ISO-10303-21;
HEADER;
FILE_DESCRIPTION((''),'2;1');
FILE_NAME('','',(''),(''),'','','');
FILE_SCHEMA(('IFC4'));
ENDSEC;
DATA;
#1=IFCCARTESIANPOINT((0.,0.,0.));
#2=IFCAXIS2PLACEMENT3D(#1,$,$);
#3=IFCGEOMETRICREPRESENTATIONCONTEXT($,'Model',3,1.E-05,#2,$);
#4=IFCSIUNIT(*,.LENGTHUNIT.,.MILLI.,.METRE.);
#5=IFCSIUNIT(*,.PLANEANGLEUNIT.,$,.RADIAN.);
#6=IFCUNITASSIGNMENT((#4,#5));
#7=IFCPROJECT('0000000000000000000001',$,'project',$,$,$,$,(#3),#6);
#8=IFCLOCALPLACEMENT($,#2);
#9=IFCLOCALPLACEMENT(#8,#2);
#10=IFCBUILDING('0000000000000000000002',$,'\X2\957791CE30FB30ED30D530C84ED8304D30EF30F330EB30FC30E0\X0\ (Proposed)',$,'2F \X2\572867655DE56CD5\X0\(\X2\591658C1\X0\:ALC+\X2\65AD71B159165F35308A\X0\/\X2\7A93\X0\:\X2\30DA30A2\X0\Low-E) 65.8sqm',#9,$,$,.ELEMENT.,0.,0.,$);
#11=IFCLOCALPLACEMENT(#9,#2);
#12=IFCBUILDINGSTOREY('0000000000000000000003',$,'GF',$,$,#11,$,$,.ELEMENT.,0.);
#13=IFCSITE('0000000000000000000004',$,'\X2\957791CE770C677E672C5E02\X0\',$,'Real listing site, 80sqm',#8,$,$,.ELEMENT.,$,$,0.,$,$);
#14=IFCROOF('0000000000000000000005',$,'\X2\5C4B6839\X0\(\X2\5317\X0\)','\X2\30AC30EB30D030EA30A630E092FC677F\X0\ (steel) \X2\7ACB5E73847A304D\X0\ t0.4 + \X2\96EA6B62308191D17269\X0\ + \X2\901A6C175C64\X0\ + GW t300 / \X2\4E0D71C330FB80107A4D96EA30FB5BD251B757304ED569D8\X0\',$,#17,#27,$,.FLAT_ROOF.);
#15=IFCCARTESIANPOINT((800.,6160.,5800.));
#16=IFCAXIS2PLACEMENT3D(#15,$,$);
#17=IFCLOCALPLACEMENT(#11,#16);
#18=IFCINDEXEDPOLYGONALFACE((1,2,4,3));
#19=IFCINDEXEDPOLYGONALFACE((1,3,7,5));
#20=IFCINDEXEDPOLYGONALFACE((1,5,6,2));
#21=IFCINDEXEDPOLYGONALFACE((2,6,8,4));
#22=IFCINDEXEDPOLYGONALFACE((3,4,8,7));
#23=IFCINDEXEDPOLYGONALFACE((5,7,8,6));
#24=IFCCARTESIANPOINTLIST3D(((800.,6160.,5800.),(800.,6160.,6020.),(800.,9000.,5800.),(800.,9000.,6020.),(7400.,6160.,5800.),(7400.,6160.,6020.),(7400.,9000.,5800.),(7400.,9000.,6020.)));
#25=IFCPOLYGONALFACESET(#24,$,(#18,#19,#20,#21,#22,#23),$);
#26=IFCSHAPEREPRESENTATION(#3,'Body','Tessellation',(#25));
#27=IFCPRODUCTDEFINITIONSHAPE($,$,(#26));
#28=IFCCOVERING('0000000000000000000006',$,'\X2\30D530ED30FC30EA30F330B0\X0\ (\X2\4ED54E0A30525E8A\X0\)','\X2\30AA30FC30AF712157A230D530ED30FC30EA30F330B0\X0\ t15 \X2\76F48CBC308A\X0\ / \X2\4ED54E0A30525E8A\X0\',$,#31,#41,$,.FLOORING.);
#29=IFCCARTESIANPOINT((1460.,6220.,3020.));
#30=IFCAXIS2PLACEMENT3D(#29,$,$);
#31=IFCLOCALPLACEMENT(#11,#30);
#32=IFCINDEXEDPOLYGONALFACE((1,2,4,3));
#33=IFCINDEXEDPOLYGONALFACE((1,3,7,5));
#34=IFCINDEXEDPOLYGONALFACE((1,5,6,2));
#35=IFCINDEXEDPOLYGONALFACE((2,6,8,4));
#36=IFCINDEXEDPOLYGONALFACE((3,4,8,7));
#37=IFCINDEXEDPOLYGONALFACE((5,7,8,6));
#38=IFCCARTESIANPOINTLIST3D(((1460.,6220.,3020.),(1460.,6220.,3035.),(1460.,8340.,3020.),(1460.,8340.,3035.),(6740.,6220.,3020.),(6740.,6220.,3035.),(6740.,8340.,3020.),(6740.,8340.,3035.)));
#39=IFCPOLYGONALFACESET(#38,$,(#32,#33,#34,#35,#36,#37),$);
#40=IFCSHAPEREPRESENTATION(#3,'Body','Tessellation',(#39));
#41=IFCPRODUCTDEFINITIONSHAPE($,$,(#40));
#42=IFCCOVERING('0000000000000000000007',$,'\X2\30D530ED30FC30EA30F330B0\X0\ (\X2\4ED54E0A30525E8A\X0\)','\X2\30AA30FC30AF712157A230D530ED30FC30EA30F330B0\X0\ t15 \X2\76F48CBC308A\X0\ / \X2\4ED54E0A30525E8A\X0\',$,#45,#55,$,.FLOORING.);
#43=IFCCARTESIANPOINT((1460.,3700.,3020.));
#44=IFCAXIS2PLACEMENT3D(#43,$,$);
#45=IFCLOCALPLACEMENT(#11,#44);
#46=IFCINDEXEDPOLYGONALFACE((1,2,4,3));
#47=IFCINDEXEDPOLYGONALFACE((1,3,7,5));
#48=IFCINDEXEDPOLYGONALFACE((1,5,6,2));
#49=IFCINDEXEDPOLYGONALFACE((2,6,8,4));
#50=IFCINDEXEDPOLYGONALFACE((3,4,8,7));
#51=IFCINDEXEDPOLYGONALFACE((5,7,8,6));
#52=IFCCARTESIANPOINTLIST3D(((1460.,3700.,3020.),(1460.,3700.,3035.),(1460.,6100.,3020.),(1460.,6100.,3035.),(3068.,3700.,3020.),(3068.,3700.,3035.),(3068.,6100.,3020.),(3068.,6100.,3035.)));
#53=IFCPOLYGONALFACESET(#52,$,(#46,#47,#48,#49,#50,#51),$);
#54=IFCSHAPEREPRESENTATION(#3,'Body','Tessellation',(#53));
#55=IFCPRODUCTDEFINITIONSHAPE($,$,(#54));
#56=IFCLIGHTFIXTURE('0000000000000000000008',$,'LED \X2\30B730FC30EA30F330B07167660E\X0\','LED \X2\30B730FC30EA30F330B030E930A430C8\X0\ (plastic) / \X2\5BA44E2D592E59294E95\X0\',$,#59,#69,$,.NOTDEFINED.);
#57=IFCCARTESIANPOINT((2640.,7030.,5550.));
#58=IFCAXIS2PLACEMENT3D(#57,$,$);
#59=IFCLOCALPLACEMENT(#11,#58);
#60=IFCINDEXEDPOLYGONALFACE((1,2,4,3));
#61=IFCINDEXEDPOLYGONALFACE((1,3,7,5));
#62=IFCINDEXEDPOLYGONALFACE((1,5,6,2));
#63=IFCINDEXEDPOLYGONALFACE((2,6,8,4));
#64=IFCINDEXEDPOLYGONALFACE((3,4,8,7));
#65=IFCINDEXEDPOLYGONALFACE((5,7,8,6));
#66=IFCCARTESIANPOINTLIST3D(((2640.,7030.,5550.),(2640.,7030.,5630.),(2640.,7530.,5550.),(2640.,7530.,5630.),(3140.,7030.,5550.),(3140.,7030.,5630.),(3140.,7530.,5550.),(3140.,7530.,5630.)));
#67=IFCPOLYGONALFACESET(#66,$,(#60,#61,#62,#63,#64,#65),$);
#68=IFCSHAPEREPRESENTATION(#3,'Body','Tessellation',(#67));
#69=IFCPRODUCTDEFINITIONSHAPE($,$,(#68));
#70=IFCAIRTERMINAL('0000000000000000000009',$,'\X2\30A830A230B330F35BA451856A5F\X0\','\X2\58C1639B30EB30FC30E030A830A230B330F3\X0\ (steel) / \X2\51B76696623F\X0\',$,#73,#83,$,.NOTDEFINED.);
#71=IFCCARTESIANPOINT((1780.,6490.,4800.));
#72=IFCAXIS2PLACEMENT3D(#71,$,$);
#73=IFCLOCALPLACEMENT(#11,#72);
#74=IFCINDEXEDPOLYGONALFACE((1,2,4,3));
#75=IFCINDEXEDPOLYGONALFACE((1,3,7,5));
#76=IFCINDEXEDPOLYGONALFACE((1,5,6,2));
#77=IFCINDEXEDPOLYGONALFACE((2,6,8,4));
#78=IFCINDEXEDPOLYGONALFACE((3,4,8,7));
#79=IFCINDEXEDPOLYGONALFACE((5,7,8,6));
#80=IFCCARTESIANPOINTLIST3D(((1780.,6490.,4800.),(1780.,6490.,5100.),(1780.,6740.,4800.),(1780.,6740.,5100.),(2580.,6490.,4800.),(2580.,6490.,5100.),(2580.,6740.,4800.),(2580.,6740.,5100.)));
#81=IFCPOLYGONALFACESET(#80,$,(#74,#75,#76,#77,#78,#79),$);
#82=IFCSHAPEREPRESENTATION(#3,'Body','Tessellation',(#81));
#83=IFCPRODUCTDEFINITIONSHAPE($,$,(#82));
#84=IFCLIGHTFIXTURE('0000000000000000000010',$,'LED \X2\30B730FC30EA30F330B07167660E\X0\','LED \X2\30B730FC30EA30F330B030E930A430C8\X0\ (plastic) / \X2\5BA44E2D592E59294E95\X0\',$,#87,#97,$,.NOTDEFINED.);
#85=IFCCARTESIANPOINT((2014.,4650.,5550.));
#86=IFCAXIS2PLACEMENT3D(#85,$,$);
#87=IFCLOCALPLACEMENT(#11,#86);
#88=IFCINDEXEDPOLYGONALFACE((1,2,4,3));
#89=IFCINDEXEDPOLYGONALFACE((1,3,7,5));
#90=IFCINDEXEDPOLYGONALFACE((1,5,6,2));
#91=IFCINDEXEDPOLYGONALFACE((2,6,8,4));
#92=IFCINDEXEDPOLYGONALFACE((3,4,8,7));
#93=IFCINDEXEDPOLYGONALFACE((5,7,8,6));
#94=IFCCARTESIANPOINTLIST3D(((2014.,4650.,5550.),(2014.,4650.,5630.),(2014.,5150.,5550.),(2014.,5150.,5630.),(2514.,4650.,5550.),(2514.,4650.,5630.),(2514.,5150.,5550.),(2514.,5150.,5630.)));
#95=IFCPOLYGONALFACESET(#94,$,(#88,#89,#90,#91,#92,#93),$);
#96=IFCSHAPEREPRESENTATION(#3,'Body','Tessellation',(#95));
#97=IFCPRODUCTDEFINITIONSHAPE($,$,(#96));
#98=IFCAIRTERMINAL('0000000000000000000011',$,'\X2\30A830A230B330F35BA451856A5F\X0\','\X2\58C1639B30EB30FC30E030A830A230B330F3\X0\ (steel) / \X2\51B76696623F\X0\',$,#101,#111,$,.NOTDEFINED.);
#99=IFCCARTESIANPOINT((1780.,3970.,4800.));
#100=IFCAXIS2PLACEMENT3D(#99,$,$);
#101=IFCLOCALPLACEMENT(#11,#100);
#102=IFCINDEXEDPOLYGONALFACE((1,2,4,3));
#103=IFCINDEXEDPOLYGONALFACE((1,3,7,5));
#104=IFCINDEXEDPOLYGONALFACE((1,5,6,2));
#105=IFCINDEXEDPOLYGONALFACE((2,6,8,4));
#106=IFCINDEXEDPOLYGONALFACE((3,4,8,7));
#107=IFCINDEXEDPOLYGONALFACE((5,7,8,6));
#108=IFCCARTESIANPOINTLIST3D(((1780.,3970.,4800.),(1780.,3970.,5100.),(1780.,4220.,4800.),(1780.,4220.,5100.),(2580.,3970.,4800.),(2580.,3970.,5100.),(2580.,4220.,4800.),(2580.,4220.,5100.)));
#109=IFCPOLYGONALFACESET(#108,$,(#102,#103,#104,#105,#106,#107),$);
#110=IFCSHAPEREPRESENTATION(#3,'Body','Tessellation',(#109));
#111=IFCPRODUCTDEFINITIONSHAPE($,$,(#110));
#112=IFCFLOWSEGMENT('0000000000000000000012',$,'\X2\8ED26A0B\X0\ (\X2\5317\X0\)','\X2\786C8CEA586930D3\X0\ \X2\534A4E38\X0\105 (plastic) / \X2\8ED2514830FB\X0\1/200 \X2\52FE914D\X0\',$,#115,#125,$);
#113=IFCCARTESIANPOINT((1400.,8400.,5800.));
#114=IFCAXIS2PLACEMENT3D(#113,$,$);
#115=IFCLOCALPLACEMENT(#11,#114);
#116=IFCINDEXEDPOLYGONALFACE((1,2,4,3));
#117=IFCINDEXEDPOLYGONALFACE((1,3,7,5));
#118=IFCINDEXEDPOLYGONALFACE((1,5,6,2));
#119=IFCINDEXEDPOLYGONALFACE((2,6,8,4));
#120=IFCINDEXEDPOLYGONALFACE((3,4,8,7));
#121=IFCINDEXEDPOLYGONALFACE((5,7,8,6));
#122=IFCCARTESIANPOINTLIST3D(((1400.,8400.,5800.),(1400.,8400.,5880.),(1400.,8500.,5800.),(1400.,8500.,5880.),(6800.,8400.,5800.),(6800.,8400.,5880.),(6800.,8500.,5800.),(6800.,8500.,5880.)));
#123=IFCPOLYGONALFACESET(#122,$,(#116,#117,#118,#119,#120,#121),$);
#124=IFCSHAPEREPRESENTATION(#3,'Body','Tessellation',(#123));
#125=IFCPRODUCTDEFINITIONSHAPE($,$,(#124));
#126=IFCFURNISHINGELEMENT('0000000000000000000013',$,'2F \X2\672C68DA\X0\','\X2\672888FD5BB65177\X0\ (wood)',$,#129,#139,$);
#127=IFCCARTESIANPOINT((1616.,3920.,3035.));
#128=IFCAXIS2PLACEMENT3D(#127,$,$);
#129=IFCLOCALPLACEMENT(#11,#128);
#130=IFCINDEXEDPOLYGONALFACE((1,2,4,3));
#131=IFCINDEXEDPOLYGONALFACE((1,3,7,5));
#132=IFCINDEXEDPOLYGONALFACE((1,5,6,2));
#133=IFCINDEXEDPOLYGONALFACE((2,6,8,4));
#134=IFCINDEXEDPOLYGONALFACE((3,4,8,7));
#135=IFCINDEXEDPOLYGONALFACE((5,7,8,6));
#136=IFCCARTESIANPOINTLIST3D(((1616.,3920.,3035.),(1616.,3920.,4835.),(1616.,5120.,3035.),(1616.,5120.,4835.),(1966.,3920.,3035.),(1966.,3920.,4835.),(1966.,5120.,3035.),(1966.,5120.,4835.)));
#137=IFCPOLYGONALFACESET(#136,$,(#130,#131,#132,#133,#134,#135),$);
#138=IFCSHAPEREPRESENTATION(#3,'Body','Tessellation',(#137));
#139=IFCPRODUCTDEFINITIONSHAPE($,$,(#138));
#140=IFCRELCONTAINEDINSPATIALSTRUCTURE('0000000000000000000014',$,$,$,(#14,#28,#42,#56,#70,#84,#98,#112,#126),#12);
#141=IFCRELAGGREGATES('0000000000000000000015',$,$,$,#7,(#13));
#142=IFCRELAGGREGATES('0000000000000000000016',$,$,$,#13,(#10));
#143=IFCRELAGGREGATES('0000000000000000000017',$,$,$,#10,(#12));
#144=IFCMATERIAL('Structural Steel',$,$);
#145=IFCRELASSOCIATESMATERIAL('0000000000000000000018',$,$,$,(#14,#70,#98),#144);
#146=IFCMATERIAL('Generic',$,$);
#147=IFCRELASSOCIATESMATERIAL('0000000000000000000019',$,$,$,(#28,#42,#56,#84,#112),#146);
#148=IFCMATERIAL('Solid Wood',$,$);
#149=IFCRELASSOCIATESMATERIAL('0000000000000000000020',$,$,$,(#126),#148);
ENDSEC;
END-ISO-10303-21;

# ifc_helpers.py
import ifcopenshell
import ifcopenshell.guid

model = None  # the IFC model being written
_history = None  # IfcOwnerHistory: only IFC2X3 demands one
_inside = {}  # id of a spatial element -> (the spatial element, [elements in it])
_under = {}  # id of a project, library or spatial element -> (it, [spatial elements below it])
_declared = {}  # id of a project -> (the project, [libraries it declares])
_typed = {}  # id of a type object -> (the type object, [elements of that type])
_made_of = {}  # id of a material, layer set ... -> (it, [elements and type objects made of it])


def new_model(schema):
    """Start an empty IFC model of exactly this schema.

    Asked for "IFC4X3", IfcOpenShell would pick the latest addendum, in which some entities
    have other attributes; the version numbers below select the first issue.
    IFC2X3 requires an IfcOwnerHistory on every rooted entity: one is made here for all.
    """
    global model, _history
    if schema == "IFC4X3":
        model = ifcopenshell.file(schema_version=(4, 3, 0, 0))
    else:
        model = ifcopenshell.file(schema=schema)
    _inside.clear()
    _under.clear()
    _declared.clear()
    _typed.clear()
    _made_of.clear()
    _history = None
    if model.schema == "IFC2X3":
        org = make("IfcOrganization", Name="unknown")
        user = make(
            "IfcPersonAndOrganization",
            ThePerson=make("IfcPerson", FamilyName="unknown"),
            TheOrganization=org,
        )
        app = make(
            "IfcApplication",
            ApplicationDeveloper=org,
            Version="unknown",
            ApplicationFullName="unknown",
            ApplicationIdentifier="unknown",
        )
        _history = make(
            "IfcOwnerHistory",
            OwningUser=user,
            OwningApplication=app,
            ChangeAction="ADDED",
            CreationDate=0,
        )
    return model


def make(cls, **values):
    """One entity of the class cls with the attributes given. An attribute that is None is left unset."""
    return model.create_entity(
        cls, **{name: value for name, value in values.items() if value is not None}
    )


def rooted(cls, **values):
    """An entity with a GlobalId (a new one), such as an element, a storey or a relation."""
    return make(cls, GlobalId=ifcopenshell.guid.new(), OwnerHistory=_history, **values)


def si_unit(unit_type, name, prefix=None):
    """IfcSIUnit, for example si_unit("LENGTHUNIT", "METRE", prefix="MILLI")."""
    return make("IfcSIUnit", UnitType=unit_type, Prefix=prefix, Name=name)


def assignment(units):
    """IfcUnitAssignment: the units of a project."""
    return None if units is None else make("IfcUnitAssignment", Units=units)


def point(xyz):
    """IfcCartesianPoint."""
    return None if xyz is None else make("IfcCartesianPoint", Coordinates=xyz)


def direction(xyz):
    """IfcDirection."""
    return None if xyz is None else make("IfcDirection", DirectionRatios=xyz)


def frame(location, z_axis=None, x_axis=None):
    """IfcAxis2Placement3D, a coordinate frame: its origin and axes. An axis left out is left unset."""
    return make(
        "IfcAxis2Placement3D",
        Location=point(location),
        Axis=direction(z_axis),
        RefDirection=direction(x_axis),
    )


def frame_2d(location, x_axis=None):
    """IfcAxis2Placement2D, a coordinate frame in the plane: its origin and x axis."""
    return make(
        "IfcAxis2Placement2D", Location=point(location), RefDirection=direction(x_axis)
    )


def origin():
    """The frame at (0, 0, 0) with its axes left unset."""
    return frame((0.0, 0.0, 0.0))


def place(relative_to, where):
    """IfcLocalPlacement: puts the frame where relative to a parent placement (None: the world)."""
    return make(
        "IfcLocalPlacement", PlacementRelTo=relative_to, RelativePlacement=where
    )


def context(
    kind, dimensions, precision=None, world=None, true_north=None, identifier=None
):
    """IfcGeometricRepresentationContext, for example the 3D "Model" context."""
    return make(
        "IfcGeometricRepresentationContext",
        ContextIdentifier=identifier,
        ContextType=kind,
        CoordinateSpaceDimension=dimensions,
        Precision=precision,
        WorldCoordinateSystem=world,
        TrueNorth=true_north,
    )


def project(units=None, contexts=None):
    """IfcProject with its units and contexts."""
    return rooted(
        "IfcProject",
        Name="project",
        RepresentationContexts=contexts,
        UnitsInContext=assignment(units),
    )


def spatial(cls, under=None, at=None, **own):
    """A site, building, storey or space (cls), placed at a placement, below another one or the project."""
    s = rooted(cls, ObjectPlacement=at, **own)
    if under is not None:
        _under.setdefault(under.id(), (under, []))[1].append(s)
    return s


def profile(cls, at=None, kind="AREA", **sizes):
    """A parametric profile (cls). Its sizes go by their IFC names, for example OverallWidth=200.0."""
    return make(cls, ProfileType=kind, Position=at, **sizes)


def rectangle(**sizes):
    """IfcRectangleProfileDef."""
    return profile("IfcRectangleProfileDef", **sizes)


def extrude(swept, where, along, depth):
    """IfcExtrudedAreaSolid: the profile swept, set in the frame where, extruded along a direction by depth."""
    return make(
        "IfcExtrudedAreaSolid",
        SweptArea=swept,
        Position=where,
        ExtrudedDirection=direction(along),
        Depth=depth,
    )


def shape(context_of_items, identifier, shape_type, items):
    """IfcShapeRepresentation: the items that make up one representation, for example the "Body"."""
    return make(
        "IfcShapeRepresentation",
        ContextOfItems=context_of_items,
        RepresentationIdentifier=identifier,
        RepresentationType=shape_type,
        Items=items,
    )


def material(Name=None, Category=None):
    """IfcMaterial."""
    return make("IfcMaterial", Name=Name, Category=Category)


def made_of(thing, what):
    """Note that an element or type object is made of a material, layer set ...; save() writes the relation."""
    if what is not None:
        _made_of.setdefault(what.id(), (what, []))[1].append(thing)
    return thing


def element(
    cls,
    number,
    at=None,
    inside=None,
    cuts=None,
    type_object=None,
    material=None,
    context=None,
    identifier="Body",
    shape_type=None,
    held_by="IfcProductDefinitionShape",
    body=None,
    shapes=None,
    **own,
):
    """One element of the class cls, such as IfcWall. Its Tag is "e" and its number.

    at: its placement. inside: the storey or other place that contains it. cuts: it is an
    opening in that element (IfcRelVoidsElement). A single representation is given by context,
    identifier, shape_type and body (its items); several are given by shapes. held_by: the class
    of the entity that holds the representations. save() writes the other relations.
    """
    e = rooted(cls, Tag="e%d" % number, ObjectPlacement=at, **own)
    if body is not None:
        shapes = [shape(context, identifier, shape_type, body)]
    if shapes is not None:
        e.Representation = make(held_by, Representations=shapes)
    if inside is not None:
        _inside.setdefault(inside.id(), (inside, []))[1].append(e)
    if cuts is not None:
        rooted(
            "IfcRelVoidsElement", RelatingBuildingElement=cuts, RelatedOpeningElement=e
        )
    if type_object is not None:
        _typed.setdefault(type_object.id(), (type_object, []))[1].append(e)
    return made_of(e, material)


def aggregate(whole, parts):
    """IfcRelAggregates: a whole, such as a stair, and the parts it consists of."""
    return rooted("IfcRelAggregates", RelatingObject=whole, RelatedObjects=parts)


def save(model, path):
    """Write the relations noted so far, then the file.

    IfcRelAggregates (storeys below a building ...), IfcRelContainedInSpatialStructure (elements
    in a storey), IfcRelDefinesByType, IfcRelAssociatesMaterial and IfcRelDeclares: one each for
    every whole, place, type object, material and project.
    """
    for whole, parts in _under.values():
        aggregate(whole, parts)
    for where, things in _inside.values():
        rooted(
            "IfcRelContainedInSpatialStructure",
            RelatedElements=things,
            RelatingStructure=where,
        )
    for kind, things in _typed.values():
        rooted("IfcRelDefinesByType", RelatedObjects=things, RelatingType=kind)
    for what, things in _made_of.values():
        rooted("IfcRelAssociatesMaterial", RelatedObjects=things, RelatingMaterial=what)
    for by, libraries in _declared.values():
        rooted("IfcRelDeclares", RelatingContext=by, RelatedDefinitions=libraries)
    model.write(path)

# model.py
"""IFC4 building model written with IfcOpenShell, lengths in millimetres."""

from ifc_helpers import new_model, si_unit, frame, frame_2d, origin, place, context, project, spatial, rectangle, extrude, material, element, save


model = new_model("IFC4")

# Units and contexts
model_context = context("Model", 3, precision=1e-05, world=origin())
ifc_project = project(units=[si_unit("LENGTHUNIT", "METRE", prefix="MILLI"), si_unit("PLANEANGLEUNIT", "RADIAN")], contexts=[model_context])

# Site, building, storey
site_placement = place(None, origin())
site = spatial("IfcSite", under=ifc_project, at=site_placement, Name="長野県松本市", ObjectType="Real listing site, 80sqm", CompositionType="ELEMENT", RefElevation=0.0)
building_placement = place(site_placement, origin())
building = spatial("IfcBuilding", under=site, at=building_placement, Name="長野・ロフト付きワンルーム (Proposed)", ObjectType="2F 在来工法(外壁:ALC+断熱外張り/窓:ペアLow-E) 65.8sqm", CompositionType="ELEMENT", ElevationOfRefHeight=0.0, ElevationOfTerrain=0.0)
storey_placement = place(building_placement, origin())
storey = spatial("IfcBuildingStorey", under=building, at=storey_placement, Name="GF", CompositionType="ELEMENT", Elevation=0.0)

# Shared definitions
ifc_material_1 = material(Name="Solid Wood")

# Roof
ifc_material_2 = material(Name="Structural Steel")
for number, where, name in (
    (1, (800.0, 6160.0, 5800.0), "屋根(北)"),
):
    element("IfcRoof", number, at=place(storey_placement, frame(where)), inside=storey, material=ifc_material_2, Name=name, Description="ガルバリウム鋼板 (steel) 立平葺き t0.4 + 雪止め金物 + 通気層 + GW t300 / 不燃・耐積雪・寒冷地仕様", PredefinedType="FLAT_ROOF", context=model_context, shape_type="SweptSolid", body=[
        extrude(rectangle(XDim=6600.0, YDim=2840.0, at=frame_2d((3300.0, 1420.0))), frame((800.0, 6160.0, 5800.0)), (0.0, 0.0, 1.0), 220.0),
    ])

# Coverings
ifc_material_3 = material(Name="Generic")
covering_1_placement = place(storey_placement, frame((1460.0, 6220.0, 3020.0)))
element("IfcCovering", 2, at=covering_1_placement, inside=storey, material=ifc_material_3, Name="フローリング (仕上げ床)", Description="オーク無垢フローリング t15 直貼り / 仕上げ床", PredefinedType="FLOORING", context=model_context, shape_type="SweptSolid", body=[
    extrude(rectangle(XDim=5280.0, YDim=2120.0, at=frame_2d((2640.0, 1060.0))), frame((1460.0, 6220.0, 3020.0)), (0.0, 0.0, 1.0), 15.0),
])
covering_2_placement = place(storey_placement, frame((1460.0, 3700.0, 3020.0)))
element("IfcCovering", 3, at=covering_2_placement, inside=storey, material=ifc_material_3, Name="フローリング (仕上げ床)", Description="オーク無垢フローリング t15 直貼り / 仕上げ床", PredefinedType="FLOORING", context=model_context, shape_type="SweptSolid", body=[
    extrude(rectangle(XDim=1608.0, YDim=2400.0, at=frame_2d((804.0, 1200.0))), frame((1460.0, 3700.0, 3020.0)), (0.0, 0.0, 1.0), 15.0),
])

# Light fixture
light_fixture_1_placement = place(storey_placement, frame((2640.0, 7030.0, 5550.0)))
element("IfcLightFixture", 4, at=light_fixture_1_placement, inside=storey, material=ifc_material_3, Name="LED シーリング照明", Description="LED シーリングライト (plastic) / 室中央天井", PredefinedType="NOTDEFINED", context=model_context, shape_type="SweptSolid", body=[
    extrude(rectangle(XDim=500.0, YDim=500.0, at=frame_2d((250.0, 250.0))), frame((2640.0, 7030.0, 5550.0)), (0.0, 0.0, 1.0), 80.0),
])

# Air terminal
air_terminal_1_placement = place(storey_placement, frame((1780.0, 6490.0, 4800.0)))
element("IfcAirTerminal", 5, at=air_terminal_1_placement, inside=storey, material=ifc_material_2, Name="エアコン室内機", Description="壁掛ルームエアコン (steel) / 冷暖房", PredefinedType="NOTDEFINED", context=model_context, shape_type="SweptSolid", body=[
    extrude(rectangle(XDim=800.0, YDim=250.0, at=frame_2d((400.0, 125.0))), frame((1780.0, 6490.0, 4800.0)), (0.0, 0.0, 1.0), 300.0),
])

# Light fixture
light_fixture_2_placement = place(storey_placement, frame((2014.0, 4650.0, 5550.0)))
element("IfcLightFixture", 6, at=light_fixture_2_placement, inside=storey, material=ifc_material_3, Name="LED シーリング照明", Description="LED シーリングライト (plastic) / 室中央天井", PredefinedType="NOTDEFINED", context=model_context, shape_type="SweptSolid", body=[
    extrude(rectangle(XDim=500.0, YDim=500.0, at=frame_2d((250.0, 250.0))), frame((2014.0, 4650.0, 5550.0)), (0.0, 0.0, 1.0), 80.0),
])

# Air terminal
air_terminal_2_placement = place(storey_placement, frame((1780.0, 3970.0, 4800.0)))
element("IfcAirTerminal", 7, at=air_terminal_2_placement, inside=storey, material=ifc_material_2, Name="エアコン室内機", Description="壁掛ルームエアコン (steel) / 冷暖房", PredefinedType="NOTDEFINED", context=model_context, shape_type="SweptSolid", body=[
    extrude(rectangle(XDim=800.0, YDim=250.0, at=frame_2d((400.0, 125.0))), frame((1780.0, 3970.0, 4800.0)), (0.0, 0.0, 1.0), 300.0),
])

# Flow segment
flow_segment_placement = place(storey_placement, frame((1400.0, 8400.0, 5800.0)))
element("IfcFlowSegment", 8, at=flow_segment_placement, inside=storey, material=ifc_material_3, Name="軒樋 (北)", Description="硬質塩ビ 半丸105 (plastic) / 軒先・1/200 勾配", context=model_context, shape_type="SweptSolid", body=[
    extrude(rectangle(XDim=5400.0, YDim=100.0, at=frame_2d((2700.0, 50.0))), frame((1400.0, 8400.0, 5800.0)), (0.0, 0.0, 1.0), 80.0),
])

# Furnishing element
furnishing_placement = place(storey_placement, frame((1616.0, 3920.0, 3035.0)))
element("IfcFurnishingElement", 9, at=furnishing_placement, inside=storey, material=ifc_material_1, Name="2F 本棚", Description="木製家具 (wood)", context=model_context, shape_type="SweptSolid", body=[
    extrude(rectangle(XDim=350.0, YDim=1200.0, at=frame_2d((175.0, 600.0))), frame((1616.0, 3920.0, 3035.0)), (0.0, 0.0, 1.0), 1800.0),
])

save(model, "model.ifc")
